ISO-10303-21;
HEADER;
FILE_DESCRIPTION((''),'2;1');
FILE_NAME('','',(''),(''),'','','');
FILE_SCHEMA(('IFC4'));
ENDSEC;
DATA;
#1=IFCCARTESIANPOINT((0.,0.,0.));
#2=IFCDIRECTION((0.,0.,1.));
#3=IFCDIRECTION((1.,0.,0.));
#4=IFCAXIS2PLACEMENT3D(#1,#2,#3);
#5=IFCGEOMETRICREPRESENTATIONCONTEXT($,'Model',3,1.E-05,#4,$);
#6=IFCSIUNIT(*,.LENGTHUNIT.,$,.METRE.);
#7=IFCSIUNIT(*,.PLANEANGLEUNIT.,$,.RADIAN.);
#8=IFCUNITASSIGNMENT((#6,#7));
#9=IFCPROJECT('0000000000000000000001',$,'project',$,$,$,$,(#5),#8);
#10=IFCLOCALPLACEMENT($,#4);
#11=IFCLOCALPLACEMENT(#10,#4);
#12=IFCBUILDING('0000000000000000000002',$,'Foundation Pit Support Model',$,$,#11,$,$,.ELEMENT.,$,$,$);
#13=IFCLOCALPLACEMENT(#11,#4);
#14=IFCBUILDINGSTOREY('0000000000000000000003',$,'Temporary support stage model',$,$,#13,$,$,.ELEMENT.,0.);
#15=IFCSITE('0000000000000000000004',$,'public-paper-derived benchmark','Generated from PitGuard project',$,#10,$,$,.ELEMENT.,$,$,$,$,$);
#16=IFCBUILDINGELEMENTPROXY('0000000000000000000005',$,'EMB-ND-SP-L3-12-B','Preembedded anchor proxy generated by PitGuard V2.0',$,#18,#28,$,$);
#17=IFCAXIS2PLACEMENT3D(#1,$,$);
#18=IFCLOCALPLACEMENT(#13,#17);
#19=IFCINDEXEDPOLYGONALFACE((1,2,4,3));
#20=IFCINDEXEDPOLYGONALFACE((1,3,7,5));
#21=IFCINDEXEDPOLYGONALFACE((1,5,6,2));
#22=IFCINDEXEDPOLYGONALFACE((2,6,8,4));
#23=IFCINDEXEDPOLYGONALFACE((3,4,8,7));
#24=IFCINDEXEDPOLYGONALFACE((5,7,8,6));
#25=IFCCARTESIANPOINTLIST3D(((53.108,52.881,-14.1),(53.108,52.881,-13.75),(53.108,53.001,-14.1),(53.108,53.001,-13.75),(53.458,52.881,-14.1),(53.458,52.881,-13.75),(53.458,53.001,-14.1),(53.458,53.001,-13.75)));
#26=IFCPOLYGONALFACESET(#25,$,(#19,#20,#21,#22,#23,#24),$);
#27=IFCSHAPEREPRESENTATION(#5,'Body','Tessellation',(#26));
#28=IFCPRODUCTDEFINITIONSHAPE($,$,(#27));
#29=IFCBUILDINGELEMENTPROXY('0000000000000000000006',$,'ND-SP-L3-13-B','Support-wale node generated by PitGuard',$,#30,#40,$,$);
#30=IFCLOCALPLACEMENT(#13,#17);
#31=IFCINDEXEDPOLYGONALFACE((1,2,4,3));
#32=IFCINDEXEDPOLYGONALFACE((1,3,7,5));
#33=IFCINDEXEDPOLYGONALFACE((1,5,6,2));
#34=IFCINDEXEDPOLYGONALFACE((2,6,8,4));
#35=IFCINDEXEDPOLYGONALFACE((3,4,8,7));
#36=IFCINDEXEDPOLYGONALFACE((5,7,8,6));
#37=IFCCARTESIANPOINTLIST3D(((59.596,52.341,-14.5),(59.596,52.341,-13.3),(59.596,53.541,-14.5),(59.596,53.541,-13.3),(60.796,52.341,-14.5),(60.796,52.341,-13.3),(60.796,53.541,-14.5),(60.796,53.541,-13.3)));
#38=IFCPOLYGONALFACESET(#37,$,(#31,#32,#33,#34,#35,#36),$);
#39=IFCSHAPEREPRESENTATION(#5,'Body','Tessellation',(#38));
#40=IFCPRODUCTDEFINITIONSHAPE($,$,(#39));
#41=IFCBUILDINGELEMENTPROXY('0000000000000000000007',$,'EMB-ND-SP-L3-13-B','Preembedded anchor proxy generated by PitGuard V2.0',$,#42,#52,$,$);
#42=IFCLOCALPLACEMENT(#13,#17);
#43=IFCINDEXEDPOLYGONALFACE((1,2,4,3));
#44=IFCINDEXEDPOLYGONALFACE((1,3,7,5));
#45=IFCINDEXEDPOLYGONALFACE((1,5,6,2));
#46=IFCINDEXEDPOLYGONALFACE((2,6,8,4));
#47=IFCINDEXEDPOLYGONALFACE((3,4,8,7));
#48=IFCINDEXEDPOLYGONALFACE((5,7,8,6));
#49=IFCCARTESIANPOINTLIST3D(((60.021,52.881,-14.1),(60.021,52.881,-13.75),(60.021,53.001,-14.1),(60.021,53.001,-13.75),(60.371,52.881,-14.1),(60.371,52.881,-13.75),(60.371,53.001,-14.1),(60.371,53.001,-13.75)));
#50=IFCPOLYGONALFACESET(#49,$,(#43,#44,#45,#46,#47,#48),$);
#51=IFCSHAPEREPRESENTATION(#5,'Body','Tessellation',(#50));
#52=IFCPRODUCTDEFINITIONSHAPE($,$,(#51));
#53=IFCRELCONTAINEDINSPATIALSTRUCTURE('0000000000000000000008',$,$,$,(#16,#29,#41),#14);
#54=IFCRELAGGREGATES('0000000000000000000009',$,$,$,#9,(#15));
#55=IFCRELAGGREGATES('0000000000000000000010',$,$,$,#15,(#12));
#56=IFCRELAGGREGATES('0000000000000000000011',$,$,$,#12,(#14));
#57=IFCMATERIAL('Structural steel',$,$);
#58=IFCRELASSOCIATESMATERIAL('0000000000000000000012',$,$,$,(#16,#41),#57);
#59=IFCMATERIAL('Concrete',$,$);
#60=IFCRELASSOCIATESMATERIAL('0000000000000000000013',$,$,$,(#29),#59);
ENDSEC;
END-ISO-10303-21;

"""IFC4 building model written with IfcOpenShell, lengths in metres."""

from ifc_helpers import new_model, si_unit, frame, origin_with_axes, origin_2d, place, context, project, spatial, rectangle, extrude, material, element, save


model = new_model("IFC4")

# Units and contexts
model_context = context("Model", 3, precision=1e-05, world=origin_with_axes())
ifc_project = project(units=[si_unit("LENGTHUNIT", "METRE"), si_unit("PLANEANGLEUNIT", "RADIAN")], contexts=[model_context])

# Site, building, storey
site_placement = place(None, origin_with_axes())
site = spatial("IfcSite", under=ifc_project, at=site_placement, Name="public-paper-derived benchmark", Description="Generated from PitGuard project", CompositionType="ELEMENT")
building_placement = place(site_placement, origin_with_axes())
building = spatial("IfcBuilding", under=site, at=building_placement, Name="Foundation Pit Support Model", CompositionType="ELEMENT")
storey_placement = place(building_placement, origin_with_axes())
storey = spatial("IfcBuildingStorey", under=building, at=storey_placement, Name="Temporary support stage model", CompositionType="ELEMENT", Elevation=0.0)

# Shared definitions
ifc_material_1 = material(Name="Structural steel")

# Shared definitions
ifc_material_2 = material(Name="Concrete")

# Building element proxies
proxy_1_placement = place(storey_placement, frame((53.283, 52.941, -14.1), z_axis=(0.0, 0.0, 1.0), x_axis=(1.0, 0.0, 0.0)))
element("IfcBuildingElementProxy", 1, at=proxy_1_placement, inside=storey, material=ifc_material_1, Name="EMB-ND-SP-L3-12-B", Description="Preembedded anchor proxy generated by PitGuard V2.0", context=model_context, shape_type="SweptSolid", body=[
    extrude(rectangle(XDim=0.35, YDim=0.12, at=origin_2d()), origin_with_axes(), (0.0, 0.0, 1.0), 0.35),
])
proxy_2_placement = place(storey_placement, frame((60.196, 52.941, -14.5), z_axis=(0.0, 0.0, 1.0), x_axis=(1.0, 0.0, 0.0)))
element("IfcBuildingElementProxy", 2, at=proxy_2_placement, inside=storey, material=ifc_material_2, Name="ND-SP-L3-13-B", Description="Support-wale node generated by PitGuard", context=model_context, shape_type="SweptSolid", body=[
    extrude(rectangle(XDim=1.2, YDim=1.2, at=origin_2d()), origin_with_axes(), (0.0, 0.0, 1.0), 1.2),
])
proxy_3_placement = place(storey_placement, frame((60.196, 52.941, -14.1), z_axis=(0.0, 0.0, 1.0), x_axis=(1.0, 0.0, 0.0)))
element("IfcBuildingElementProxy", 3, at=proxy_3_placement, inside=storey, material=ifc_material_1, Name="EMB-ND-SP-L3-13-B", Description="Preembedded anchor proxy generated by PitGuard V2.0", context=model_context, shape_type="SweptSolid", body=[
    extrude(rectangle(XDim=0.35, YDim=0.12, at=origin_2d()), origin_with_axes(), (0.0, 0.0, 1.0), 0.35),
])

save(model, "model.ifc")
